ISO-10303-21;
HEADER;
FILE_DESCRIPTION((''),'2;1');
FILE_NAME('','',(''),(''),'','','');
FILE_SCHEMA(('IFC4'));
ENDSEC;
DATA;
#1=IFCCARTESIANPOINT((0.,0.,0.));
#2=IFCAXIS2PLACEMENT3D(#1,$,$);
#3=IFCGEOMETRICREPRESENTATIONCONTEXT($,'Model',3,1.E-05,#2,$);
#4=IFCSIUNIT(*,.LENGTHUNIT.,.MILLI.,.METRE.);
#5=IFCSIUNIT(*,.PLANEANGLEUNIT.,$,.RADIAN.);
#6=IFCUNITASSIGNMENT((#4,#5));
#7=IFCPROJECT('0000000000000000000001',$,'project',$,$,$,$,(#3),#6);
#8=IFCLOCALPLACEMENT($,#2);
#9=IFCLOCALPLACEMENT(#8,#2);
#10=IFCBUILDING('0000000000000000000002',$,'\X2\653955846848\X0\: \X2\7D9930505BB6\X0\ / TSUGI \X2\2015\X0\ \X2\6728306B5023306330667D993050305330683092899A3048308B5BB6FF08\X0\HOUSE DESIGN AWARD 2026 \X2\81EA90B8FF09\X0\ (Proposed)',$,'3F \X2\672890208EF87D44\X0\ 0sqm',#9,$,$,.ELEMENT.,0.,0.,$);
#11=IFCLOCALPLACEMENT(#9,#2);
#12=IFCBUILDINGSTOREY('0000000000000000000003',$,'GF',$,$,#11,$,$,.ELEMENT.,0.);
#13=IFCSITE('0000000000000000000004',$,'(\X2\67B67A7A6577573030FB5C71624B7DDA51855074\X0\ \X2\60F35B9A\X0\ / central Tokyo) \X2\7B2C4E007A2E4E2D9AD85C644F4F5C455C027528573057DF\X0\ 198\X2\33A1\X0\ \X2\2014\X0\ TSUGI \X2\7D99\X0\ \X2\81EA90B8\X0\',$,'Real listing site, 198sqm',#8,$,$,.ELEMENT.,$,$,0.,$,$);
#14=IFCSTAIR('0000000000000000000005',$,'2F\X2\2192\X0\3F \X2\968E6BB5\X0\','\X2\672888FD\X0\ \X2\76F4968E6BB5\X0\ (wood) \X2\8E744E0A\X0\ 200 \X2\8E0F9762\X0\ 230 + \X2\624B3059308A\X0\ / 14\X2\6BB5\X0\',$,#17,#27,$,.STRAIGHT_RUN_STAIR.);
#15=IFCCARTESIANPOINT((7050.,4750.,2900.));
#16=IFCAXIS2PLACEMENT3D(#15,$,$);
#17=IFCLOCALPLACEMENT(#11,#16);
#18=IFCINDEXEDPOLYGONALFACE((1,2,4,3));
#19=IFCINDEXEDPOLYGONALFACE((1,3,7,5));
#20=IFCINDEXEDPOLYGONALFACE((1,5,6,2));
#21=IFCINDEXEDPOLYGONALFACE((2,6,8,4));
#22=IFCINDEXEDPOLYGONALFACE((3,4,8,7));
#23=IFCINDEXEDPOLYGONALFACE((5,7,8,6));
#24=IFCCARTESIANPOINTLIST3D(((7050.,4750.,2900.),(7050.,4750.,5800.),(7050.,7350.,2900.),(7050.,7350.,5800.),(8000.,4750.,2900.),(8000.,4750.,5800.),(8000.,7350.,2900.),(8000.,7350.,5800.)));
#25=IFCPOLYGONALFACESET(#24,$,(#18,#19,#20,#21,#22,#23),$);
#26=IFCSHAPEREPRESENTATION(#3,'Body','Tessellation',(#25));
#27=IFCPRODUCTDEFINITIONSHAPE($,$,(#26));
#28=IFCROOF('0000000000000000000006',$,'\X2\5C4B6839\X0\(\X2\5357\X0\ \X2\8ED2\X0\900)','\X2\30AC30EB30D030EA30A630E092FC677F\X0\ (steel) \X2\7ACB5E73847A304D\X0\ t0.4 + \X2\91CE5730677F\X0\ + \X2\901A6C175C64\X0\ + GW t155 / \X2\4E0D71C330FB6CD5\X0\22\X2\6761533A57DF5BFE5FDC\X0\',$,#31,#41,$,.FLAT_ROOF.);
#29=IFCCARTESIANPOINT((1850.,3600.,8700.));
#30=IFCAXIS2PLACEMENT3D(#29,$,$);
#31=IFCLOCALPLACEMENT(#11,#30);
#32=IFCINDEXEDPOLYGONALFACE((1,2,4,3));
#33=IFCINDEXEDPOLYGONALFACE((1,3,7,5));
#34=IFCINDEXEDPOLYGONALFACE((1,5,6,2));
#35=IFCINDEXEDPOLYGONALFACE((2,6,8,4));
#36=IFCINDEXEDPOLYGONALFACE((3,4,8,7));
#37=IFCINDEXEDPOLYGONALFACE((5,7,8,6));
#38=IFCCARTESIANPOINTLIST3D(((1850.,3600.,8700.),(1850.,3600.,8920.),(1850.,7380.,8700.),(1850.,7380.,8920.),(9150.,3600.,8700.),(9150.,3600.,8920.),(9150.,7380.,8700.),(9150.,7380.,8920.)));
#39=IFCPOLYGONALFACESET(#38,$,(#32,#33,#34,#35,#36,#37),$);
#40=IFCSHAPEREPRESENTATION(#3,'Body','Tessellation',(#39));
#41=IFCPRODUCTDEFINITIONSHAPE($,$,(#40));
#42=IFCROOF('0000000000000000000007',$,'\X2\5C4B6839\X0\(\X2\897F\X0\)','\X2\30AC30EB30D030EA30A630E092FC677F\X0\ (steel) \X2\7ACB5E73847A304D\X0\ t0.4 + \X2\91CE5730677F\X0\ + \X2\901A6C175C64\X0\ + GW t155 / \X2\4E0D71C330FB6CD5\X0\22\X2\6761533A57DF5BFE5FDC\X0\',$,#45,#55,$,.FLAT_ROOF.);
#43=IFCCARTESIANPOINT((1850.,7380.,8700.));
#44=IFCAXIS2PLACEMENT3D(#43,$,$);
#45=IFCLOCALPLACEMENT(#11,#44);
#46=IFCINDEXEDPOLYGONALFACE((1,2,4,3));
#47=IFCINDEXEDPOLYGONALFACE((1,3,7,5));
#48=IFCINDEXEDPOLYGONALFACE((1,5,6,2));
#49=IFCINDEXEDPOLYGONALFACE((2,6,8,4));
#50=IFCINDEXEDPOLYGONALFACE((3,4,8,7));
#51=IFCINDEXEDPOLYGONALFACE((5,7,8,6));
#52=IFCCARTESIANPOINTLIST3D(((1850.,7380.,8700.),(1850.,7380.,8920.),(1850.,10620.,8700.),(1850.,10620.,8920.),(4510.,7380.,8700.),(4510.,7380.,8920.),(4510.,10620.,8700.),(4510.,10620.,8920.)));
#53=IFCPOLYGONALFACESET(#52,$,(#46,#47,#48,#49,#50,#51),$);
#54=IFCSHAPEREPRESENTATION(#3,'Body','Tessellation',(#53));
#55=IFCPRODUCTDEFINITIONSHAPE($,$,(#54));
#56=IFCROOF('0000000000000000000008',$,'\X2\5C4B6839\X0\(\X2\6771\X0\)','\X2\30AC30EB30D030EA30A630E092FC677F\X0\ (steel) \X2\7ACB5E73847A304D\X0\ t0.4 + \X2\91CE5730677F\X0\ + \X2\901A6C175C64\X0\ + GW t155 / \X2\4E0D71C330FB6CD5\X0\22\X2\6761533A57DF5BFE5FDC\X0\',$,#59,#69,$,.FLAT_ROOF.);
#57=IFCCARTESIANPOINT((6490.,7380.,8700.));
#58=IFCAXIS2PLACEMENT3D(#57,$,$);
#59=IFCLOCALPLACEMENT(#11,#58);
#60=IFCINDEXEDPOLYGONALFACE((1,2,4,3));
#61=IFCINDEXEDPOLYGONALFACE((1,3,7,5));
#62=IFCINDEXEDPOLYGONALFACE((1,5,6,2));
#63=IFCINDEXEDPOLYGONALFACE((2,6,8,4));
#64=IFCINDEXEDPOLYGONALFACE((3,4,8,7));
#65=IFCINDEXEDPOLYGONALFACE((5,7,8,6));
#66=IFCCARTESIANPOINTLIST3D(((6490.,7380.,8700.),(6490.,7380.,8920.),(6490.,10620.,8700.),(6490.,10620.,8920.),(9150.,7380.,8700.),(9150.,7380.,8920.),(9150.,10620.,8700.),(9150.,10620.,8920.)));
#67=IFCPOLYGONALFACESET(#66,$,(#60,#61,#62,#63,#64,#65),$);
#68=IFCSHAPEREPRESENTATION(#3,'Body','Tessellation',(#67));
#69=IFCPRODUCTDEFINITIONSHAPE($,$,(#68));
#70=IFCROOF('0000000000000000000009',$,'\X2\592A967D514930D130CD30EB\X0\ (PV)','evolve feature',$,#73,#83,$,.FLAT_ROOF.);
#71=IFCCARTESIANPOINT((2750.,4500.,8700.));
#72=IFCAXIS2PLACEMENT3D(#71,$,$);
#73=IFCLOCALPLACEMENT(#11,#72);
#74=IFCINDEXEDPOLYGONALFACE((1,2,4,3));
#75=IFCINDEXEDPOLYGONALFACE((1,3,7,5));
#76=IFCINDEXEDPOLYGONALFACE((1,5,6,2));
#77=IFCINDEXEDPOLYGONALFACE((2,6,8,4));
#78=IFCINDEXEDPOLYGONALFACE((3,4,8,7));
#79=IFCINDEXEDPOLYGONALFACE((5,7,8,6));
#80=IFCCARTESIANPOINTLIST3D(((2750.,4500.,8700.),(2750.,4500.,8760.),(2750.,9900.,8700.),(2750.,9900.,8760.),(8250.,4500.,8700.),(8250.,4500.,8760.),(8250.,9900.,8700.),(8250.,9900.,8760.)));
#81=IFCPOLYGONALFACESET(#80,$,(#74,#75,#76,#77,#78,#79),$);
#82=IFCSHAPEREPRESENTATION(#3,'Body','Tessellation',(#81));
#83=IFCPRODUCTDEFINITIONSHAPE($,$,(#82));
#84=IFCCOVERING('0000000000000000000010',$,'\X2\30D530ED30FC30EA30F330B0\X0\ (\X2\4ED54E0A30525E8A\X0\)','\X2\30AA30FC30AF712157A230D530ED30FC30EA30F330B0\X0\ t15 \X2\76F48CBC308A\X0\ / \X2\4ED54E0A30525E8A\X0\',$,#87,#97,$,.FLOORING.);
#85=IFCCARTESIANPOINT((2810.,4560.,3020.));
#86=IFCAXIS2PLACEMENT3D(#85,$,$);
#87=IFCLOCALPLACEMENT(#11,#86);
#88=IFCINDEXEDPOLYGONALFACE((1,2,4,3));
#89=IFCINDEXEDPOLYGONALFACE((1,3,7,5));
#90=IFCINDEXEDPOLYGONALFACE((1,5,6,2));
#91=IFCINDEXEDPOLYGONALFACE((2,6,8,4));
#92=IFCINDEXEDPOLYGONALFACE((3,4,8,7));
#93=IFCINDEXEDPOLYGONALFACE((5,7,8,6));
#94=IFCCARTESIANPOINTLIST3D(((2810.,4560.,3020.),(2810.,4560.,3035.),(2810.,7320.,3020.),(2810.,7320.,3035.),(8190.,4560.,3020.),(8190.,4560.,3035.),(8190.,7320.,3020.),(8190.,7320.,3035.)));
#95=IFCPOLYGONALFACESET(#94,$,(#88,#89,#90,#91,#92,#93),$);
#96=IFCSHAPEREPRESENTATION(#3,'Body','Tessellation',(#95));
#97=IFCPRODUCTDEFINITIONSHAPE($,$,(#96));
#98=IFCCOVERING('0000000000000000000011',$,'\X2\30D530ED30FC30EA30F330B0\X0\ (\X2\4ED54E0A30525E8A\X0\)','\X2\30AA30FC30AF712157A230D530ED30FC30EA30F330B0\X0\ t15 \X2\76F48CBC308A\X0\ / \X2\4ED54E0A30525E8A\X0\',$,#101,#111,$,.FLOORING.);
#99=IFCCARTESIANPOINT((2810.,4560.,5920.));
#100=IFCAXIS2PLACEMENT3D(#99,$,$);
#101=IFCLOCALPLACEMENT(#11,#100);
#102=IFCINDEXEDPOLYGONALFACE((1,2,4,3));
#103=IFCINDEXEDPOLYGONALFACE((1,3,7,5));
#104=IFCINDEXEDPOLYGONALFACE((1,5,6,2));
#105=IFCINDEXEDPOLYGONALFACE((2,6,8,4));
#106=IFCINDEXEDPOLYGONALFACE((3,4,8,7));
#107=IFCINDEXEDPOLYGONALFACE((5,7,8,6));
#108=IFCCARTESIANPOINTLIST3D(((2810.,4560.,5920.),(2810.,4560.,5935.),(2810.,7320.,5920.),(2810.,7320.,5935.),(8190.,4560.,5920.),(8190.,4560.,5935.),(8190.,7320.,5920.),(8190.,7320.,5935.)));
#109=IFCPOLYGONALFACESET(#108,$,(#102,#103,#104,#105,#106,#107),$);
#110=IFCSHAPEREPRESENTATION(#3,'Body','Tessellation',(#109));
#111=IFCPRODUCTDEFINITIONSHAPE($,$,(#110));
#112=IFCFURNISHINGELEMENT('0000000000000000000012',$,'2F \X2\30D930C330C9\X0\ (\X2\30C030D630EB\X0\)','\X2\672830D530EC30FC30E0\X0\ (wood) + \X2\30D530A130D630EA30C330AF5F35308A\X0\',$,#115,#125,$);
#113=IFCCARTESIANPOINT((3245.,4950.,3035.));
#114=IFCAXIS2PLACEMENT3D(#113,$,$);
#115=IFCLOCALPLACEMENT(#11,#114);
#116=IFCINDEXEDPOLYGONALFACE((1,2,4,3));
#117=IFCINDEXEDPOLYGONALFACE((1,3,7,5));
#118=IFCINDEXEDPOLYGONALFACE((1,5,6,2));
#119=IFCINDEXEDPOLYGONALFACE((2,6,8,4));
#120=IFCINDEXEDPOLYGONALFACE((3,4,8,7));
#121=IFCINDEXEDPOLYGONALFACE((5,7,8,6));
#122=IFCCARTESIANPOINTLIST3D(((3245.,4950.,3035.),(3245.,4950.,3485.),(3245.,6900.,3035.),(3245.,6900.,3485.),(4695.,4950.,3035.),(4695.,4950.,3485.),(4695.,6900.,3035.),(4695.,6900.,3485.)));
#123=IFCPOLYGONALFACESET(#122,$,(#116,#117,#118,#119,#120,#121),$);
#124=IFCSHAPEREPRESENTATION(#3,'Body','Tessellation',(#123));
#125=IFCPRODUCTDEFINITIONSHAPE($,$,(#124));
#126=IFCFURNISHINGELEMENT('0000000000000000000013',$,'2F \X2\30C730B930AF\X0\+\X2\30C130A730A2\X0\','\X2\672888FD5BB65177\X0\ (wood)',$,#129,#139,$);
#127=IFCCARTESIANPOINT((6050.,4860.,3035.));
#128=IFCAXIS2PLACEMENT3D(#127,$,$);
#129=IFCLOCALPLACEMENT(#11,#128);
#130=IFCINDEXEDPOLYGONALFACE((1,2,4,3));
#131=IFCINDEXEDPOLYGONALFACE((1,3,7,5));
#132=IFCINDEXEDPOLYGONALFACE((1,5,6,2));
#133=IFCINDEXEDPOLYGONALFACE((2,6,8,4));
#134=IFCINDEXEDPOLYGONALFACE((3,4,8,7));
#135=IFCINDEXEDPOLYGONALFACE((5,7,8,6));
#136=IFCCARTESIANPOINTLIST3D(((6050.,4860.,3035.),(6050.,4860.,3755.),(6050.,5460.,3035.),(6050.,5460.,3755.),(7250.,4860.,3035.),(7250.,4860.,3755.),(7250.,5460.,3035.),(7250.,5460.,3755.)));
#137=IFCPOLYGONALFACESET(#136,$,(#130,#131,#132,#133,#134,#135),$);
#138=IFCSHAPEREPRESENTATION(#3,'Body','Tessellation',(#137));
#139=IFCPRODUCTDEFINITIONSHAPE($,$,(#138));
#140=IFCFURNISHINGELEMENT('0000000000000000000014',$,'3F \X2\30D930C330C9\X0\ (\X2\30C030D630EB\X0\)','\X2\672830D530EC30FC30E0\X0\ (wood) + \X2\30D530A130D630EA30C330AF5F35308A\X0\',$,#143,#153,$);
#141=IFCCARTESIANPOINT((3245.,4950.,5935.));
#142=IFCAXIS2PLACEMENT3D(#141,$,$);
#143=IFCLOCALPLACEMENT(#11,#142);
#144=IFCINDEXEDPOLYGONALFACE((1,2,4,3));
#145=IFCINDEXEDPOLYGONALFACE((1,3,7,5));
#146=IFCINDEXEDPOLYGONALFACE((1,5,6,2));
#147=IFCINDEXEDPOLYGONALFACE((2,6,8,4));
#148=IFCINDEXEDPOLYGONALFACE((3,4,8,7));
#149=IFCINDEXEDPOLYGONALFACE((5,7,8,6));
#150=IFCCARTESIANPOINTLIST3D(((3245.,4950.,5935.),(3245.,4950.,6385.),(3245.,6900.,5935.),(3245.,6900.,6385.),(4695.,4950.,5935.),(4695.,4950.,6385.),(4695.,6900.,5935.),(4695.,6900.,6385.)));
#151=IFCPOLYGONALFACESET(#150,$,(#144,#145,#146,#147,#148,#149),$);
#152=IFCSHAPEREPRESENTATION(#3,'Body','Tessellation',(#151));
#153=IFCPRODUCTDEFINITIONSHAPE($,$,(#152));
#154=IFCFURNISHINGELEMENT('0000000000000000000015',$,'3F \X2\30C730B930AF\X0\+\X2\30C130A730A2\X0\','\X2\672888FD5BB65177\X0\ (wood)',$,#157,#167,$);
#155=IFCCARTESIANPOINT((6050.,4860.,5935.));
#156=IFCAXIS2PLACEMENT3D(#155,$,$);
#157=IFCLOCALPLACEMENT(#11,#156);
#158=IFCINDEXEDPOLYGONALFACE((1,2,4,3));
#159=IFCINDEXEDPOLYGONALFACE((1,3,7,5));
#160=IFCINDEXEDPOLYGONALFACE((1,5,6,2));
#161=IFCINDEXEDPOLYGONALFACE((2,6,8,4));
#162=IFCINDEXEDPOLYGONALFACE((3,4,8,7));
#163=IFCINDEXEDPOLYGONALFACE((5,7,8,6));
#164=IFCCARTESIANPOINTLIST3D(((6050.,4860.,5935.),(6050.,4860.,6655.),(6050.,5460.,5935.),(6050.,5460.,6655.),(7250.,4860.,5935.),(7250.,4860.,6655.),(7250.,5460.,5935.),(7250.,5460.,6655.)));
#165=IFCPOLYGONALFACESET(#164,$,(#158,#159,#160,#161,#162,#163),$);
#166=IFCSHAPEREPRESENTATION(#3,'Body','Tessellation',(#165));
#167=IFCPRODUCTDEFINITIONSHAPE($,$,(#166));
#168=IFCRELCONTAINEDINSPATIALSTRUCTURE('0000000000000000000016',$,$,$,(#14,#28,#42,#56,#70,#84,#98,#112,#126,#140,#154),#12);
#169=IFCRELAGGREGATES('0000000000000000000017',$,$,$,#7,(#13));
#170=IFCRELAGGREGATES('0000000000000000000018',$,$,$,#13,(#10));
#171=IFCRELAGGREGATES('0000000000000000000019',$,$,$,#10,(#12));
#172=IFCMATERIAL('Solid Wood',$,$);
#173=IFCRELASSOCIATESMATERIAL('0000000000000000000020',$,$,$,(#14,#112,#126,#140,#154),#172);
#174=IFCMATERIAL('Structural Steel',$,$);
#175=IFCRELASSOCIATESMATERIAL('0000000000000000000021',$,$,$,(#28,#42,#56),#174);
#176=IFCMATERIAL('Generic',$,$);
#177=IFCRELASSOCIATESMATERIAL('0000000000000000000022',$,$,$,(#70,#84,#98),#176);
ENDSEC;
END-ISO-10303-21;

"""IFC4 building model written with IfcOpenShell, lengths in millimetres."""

from ifc_helpers import new_model, si_unit, frame, frame_2d, origin, place, context, project, spatial, rectangle, extrude, material, element, save


model = new_model("IFC4")

# Units and contexts
model_context = context("Model", 3, precision=1e-05, world=origin())
ifc_project = project(units=[si_unit("LENGTHUNIT", "METRE", prefix="MILLI"), si_unit("PLANEANGLEUNIT", "RADIAN")], contexts=[model_context])

# Site, building, storey
site_placement = place(None, origin())
site = spatial("IfcSite", under=ifc_project, at=site_placement, Name="(架空敷地・山手線内側 想定 / central Tokyo) 第一種中高層住居専用地域 198㎡ — TSUGI 継 自邸", ObjectType="Real listing site, 198sqm", CompositionType="ELEMENT", RefElevation=0.0)
building_placement = place(site_placement, origin())
building = spatial("IfcBuilding", under=site, at=building_placement, Name="改善案: 継ぐ家 / TSUGI ― 木に倣って継ぐことを覚える家（HOUSE DESIGN AWARD 2026 自邸） (Proposed)", ObjectType="3F 木造軸組 0sqm", CompositionType="ELEMENT", ElevationOfRefHeight=0.0, ElevationOfTerrain=0.0)
storey_placement = place(building_placement, origin())
storey = spatial("IfcBuildingStorey", under=building, at=storey_placement, Name="GF", CompositionType="ELEMENT", Elevation=0.0)

# Shared definitions
ifc_material_1 = material(Name="Solid Wood")

# Stair
stair_placement = place(storey_placement, frame((7050.0, 4750.0, 2900.0)))
element("IfcStair", 1, at=stair_placement, inside=storey, material=ifc_material_1, Name="2F→3F 階段", Description="木製 直階段 (wood) 蹴上 200 踏面 230 + 手すり / 14段", PredefinedType="STRAIGHT_RUN_STAIR", context=model_context, shape_type="SweptSolid", body=[
    extrude(rectangle(XDim=950.0, YDim=2600.0, at=frame_2d((475.0, 1300.0))), frame((7050.0, 4750.0, 2900.0)), (0.0, 0.0, 1.0), 2900.0),
])

# Roofs
ifc_material_2 = material(Name="Structural Steel")
roof_1_placement = place(storey_placement, frame((1850.0, 3600.0, 8700.0)))
element("IfcRoof", 2, at=roof_1_placement, inside=storey, material=ifc_material_2, Name="屋根(南 軒900)", Description="ガルバリウム鋼板 (steel) 立平葺き t0.4 + 野地板 + 通気層 + GW t155 / 不燃・法22条区域対応", PredefinedType="FLAT_ROOF", context=model_context, shape_type="SweptSolid", body=[
    extrude(rectangle(XDim=7300.0, YDim=3780.0, at=frame_2d((3650.0, 1890.0))), frame((1850.0, 3600.0, 8700.0)), (0.0, 0.0, 1.0), 220.0),
])
roof_2_placement = place(storey_placement, frame((1850.0, 7380.0, 8700.0)))
element("IfcRoof", 3, at=roof_2_placement, inside=storey, material=ifc_material_2, Name="屋根(西)", Description="ガルバリウム鋼板 (steel) 立平葺き t0.4 + 野地板 + 通気層 + GW t155 / 不燃・法22条区域対応", PredefinedType="FLAT_ROOF", context=model_context, shape_type="SweptSolid", body=[
    extrude(rectangle(XDim=2660.0, YDim=3240.0, at=frame_2d((1330.0, 1620.0))), frame((1850.0, 7380.0, 8700.0)), (0.0, 0.0, 1.0), 220.0),
])
roof_3_placement = place(storey_placement, frame((6490.0, 7380.0, 8700.0)))
element("IfcRoof", 4, at=roof_3_placement, inside=storey, material=ifc_material_2, Name="屋根(東)", Description="ガルバリウム鋼板 (steel) 立平葺き t0.4 + 野地板 + 通気層 + GW t155 / 不燃・法22条区域対応", PredefinedType="FLAT_ROOF", context=model_context, shape_type="SweptSolid", body=[
    extrude(rectangle(XDim=2660.0, YDim=3240.0, at=frame_2d((1330.0, 1620.0))), frame((6490.0, 7380.0, 8700.0)), (0.0, 0.0, 1.0), 220.0),
])
ifc_material_3 = material(Name="Generic")
roof_4_placement = place(storey_placement, frame((2750.0, 4500.0, 8700.0)))
element("IfcRoof", 5, at=roof_4_placement, inside=storey, material=ifc_material_3, Name="太陽光パネル (PV)", Description="evolve feature", PredefinedType="FLAT_ROOF", context=model_context, shape_type="SweptSolid", body=[
    extrude(rectangle(XDim=5500.0, YDim=5400.0, at=frame_2d((2750.0, 2700.0))), frame((2750.0, 4500.0, 8700.0)), (0.0, 0.0, 1.0), 60.0),
])

# Coverings
covering_1_placement = place(storey_placement, frame((2810.0, 4560.0, 3020.0)))
element("IfcCovering", 6, at=covering_1_placement, inside=storey, material=ifc_material_3, Name="フローリング (仕上げ床)", Description="オーク無垢フローリング t15 直貼り / 仕上げ床", PredefinedType="FLOORING", context=model_context, shape_type="SweptSolid", body=[
    extrude(rectangle(XDim=5380.0, YDim=2760.0, at=frame_2d((2690.0, 1380.0))), frame((2810.0, 4560.0, 3020.0)), (0.0, 0.0, 1.0), 15.0),
])
covering_2_placement = place(storey_placement, frame((2810.0, 4560.0, 5920.0)))
element("IfcCovering", 7, at=covering_2_placement, inside=storey, material=ifc_material_3, Name="フローリング (仕上げ床)", Description="オーク無垢フローリング t15 直貼り / 仕上げ床", PredefinedType="FLOORING", context=model_context, shape_type="SweptSolid", body=[
    extrude(rectangle(XDim=5380.0, YDim=2760.0, at=frame_2d((2690.0, 1380.0))), frame((2810.0, 4560.0, 5920.0)), (0.0, 0.0, 1.0), 15.0),
])

# Furnishing elements
furnishing_1_placement = place(storey_placement, frame((3245.0, 4950.0, 3035.0)))
element("IfcFurnishingElement", 8, at=furnishing_1_placement, inside=storey, material=ifc_material_1, Name="2F ベッド (ダブル)", Description="木フレーム (wood) + ファブリック張り", context=model_context, shape_type="SweptSolid", body=[
    extrude(rectangle(XDim=1450.0, YDim=1950.0, at=frame_2d((725.0, 975.0))), frame((3245.0, 4950.0, 3035.0)), (0.0, 0.0, 1.0), 450.0),
])
furnishing_2_placement = place(storey_placement, frame((6050.0, 4860.0, 3035.0)))
element("IfcFurnishingElement", 9, at=furnishing_2_placement, inside=storey, material=ifc_material_1, Name="2F デスク+チェア", Description="木製家具 (wood)", context=model_context, shape_type="SweptSolid", body=[
    extrude(rectangle(XDim=1200.0, YDim=600.0, at=frame_2d((600.0, 300.0))), frame((6050.0, 4860.0, 3035.0)), (0.0, 0.0, 1.0), 720.0),
])
furnishing_3_placement = place(storey_placement, frame((3245.0, 4950.0, 5935.0)))
element("IfcFurnishingElement", 10, at=furnishing_3_placement, inside=storey, material=ifc_material_1, Name="3F ベッド (ダブル)", Description="木フレーム (wood) + ファブリック張り", context=model_context, shape_type="SweptSolid", body=[
    extrude(rectangle(XDim=1450.0, YDim=1950.0, at=frame_2d((725.0, 975.0))), frame((3245.0, 4950.0, 5935.0)), (0.0, 0.0, 1.0), 450.0),
])
furnishing_4_placement = place(storey_placement, frame((6050.0, 4860.0, 5935.0)))
element("IfcFurnishingElement", 11, at=furnishing_4_placement, inside=storey, material=ifc_material_1, Name="3F デスク+チェア", Description="木製家具 (wood)", context=model_context, shape_type="SweptSolid", body=[
    extrude(rectangle(XDim=1200.0, YDim=600.0, at=frame_2d((600.0, 300.0))), frame((6050.0, 4860.0, 5935.0)), (0.0, 0.0, 1.0), 720.0),
])

save(model, "model.ifc")
